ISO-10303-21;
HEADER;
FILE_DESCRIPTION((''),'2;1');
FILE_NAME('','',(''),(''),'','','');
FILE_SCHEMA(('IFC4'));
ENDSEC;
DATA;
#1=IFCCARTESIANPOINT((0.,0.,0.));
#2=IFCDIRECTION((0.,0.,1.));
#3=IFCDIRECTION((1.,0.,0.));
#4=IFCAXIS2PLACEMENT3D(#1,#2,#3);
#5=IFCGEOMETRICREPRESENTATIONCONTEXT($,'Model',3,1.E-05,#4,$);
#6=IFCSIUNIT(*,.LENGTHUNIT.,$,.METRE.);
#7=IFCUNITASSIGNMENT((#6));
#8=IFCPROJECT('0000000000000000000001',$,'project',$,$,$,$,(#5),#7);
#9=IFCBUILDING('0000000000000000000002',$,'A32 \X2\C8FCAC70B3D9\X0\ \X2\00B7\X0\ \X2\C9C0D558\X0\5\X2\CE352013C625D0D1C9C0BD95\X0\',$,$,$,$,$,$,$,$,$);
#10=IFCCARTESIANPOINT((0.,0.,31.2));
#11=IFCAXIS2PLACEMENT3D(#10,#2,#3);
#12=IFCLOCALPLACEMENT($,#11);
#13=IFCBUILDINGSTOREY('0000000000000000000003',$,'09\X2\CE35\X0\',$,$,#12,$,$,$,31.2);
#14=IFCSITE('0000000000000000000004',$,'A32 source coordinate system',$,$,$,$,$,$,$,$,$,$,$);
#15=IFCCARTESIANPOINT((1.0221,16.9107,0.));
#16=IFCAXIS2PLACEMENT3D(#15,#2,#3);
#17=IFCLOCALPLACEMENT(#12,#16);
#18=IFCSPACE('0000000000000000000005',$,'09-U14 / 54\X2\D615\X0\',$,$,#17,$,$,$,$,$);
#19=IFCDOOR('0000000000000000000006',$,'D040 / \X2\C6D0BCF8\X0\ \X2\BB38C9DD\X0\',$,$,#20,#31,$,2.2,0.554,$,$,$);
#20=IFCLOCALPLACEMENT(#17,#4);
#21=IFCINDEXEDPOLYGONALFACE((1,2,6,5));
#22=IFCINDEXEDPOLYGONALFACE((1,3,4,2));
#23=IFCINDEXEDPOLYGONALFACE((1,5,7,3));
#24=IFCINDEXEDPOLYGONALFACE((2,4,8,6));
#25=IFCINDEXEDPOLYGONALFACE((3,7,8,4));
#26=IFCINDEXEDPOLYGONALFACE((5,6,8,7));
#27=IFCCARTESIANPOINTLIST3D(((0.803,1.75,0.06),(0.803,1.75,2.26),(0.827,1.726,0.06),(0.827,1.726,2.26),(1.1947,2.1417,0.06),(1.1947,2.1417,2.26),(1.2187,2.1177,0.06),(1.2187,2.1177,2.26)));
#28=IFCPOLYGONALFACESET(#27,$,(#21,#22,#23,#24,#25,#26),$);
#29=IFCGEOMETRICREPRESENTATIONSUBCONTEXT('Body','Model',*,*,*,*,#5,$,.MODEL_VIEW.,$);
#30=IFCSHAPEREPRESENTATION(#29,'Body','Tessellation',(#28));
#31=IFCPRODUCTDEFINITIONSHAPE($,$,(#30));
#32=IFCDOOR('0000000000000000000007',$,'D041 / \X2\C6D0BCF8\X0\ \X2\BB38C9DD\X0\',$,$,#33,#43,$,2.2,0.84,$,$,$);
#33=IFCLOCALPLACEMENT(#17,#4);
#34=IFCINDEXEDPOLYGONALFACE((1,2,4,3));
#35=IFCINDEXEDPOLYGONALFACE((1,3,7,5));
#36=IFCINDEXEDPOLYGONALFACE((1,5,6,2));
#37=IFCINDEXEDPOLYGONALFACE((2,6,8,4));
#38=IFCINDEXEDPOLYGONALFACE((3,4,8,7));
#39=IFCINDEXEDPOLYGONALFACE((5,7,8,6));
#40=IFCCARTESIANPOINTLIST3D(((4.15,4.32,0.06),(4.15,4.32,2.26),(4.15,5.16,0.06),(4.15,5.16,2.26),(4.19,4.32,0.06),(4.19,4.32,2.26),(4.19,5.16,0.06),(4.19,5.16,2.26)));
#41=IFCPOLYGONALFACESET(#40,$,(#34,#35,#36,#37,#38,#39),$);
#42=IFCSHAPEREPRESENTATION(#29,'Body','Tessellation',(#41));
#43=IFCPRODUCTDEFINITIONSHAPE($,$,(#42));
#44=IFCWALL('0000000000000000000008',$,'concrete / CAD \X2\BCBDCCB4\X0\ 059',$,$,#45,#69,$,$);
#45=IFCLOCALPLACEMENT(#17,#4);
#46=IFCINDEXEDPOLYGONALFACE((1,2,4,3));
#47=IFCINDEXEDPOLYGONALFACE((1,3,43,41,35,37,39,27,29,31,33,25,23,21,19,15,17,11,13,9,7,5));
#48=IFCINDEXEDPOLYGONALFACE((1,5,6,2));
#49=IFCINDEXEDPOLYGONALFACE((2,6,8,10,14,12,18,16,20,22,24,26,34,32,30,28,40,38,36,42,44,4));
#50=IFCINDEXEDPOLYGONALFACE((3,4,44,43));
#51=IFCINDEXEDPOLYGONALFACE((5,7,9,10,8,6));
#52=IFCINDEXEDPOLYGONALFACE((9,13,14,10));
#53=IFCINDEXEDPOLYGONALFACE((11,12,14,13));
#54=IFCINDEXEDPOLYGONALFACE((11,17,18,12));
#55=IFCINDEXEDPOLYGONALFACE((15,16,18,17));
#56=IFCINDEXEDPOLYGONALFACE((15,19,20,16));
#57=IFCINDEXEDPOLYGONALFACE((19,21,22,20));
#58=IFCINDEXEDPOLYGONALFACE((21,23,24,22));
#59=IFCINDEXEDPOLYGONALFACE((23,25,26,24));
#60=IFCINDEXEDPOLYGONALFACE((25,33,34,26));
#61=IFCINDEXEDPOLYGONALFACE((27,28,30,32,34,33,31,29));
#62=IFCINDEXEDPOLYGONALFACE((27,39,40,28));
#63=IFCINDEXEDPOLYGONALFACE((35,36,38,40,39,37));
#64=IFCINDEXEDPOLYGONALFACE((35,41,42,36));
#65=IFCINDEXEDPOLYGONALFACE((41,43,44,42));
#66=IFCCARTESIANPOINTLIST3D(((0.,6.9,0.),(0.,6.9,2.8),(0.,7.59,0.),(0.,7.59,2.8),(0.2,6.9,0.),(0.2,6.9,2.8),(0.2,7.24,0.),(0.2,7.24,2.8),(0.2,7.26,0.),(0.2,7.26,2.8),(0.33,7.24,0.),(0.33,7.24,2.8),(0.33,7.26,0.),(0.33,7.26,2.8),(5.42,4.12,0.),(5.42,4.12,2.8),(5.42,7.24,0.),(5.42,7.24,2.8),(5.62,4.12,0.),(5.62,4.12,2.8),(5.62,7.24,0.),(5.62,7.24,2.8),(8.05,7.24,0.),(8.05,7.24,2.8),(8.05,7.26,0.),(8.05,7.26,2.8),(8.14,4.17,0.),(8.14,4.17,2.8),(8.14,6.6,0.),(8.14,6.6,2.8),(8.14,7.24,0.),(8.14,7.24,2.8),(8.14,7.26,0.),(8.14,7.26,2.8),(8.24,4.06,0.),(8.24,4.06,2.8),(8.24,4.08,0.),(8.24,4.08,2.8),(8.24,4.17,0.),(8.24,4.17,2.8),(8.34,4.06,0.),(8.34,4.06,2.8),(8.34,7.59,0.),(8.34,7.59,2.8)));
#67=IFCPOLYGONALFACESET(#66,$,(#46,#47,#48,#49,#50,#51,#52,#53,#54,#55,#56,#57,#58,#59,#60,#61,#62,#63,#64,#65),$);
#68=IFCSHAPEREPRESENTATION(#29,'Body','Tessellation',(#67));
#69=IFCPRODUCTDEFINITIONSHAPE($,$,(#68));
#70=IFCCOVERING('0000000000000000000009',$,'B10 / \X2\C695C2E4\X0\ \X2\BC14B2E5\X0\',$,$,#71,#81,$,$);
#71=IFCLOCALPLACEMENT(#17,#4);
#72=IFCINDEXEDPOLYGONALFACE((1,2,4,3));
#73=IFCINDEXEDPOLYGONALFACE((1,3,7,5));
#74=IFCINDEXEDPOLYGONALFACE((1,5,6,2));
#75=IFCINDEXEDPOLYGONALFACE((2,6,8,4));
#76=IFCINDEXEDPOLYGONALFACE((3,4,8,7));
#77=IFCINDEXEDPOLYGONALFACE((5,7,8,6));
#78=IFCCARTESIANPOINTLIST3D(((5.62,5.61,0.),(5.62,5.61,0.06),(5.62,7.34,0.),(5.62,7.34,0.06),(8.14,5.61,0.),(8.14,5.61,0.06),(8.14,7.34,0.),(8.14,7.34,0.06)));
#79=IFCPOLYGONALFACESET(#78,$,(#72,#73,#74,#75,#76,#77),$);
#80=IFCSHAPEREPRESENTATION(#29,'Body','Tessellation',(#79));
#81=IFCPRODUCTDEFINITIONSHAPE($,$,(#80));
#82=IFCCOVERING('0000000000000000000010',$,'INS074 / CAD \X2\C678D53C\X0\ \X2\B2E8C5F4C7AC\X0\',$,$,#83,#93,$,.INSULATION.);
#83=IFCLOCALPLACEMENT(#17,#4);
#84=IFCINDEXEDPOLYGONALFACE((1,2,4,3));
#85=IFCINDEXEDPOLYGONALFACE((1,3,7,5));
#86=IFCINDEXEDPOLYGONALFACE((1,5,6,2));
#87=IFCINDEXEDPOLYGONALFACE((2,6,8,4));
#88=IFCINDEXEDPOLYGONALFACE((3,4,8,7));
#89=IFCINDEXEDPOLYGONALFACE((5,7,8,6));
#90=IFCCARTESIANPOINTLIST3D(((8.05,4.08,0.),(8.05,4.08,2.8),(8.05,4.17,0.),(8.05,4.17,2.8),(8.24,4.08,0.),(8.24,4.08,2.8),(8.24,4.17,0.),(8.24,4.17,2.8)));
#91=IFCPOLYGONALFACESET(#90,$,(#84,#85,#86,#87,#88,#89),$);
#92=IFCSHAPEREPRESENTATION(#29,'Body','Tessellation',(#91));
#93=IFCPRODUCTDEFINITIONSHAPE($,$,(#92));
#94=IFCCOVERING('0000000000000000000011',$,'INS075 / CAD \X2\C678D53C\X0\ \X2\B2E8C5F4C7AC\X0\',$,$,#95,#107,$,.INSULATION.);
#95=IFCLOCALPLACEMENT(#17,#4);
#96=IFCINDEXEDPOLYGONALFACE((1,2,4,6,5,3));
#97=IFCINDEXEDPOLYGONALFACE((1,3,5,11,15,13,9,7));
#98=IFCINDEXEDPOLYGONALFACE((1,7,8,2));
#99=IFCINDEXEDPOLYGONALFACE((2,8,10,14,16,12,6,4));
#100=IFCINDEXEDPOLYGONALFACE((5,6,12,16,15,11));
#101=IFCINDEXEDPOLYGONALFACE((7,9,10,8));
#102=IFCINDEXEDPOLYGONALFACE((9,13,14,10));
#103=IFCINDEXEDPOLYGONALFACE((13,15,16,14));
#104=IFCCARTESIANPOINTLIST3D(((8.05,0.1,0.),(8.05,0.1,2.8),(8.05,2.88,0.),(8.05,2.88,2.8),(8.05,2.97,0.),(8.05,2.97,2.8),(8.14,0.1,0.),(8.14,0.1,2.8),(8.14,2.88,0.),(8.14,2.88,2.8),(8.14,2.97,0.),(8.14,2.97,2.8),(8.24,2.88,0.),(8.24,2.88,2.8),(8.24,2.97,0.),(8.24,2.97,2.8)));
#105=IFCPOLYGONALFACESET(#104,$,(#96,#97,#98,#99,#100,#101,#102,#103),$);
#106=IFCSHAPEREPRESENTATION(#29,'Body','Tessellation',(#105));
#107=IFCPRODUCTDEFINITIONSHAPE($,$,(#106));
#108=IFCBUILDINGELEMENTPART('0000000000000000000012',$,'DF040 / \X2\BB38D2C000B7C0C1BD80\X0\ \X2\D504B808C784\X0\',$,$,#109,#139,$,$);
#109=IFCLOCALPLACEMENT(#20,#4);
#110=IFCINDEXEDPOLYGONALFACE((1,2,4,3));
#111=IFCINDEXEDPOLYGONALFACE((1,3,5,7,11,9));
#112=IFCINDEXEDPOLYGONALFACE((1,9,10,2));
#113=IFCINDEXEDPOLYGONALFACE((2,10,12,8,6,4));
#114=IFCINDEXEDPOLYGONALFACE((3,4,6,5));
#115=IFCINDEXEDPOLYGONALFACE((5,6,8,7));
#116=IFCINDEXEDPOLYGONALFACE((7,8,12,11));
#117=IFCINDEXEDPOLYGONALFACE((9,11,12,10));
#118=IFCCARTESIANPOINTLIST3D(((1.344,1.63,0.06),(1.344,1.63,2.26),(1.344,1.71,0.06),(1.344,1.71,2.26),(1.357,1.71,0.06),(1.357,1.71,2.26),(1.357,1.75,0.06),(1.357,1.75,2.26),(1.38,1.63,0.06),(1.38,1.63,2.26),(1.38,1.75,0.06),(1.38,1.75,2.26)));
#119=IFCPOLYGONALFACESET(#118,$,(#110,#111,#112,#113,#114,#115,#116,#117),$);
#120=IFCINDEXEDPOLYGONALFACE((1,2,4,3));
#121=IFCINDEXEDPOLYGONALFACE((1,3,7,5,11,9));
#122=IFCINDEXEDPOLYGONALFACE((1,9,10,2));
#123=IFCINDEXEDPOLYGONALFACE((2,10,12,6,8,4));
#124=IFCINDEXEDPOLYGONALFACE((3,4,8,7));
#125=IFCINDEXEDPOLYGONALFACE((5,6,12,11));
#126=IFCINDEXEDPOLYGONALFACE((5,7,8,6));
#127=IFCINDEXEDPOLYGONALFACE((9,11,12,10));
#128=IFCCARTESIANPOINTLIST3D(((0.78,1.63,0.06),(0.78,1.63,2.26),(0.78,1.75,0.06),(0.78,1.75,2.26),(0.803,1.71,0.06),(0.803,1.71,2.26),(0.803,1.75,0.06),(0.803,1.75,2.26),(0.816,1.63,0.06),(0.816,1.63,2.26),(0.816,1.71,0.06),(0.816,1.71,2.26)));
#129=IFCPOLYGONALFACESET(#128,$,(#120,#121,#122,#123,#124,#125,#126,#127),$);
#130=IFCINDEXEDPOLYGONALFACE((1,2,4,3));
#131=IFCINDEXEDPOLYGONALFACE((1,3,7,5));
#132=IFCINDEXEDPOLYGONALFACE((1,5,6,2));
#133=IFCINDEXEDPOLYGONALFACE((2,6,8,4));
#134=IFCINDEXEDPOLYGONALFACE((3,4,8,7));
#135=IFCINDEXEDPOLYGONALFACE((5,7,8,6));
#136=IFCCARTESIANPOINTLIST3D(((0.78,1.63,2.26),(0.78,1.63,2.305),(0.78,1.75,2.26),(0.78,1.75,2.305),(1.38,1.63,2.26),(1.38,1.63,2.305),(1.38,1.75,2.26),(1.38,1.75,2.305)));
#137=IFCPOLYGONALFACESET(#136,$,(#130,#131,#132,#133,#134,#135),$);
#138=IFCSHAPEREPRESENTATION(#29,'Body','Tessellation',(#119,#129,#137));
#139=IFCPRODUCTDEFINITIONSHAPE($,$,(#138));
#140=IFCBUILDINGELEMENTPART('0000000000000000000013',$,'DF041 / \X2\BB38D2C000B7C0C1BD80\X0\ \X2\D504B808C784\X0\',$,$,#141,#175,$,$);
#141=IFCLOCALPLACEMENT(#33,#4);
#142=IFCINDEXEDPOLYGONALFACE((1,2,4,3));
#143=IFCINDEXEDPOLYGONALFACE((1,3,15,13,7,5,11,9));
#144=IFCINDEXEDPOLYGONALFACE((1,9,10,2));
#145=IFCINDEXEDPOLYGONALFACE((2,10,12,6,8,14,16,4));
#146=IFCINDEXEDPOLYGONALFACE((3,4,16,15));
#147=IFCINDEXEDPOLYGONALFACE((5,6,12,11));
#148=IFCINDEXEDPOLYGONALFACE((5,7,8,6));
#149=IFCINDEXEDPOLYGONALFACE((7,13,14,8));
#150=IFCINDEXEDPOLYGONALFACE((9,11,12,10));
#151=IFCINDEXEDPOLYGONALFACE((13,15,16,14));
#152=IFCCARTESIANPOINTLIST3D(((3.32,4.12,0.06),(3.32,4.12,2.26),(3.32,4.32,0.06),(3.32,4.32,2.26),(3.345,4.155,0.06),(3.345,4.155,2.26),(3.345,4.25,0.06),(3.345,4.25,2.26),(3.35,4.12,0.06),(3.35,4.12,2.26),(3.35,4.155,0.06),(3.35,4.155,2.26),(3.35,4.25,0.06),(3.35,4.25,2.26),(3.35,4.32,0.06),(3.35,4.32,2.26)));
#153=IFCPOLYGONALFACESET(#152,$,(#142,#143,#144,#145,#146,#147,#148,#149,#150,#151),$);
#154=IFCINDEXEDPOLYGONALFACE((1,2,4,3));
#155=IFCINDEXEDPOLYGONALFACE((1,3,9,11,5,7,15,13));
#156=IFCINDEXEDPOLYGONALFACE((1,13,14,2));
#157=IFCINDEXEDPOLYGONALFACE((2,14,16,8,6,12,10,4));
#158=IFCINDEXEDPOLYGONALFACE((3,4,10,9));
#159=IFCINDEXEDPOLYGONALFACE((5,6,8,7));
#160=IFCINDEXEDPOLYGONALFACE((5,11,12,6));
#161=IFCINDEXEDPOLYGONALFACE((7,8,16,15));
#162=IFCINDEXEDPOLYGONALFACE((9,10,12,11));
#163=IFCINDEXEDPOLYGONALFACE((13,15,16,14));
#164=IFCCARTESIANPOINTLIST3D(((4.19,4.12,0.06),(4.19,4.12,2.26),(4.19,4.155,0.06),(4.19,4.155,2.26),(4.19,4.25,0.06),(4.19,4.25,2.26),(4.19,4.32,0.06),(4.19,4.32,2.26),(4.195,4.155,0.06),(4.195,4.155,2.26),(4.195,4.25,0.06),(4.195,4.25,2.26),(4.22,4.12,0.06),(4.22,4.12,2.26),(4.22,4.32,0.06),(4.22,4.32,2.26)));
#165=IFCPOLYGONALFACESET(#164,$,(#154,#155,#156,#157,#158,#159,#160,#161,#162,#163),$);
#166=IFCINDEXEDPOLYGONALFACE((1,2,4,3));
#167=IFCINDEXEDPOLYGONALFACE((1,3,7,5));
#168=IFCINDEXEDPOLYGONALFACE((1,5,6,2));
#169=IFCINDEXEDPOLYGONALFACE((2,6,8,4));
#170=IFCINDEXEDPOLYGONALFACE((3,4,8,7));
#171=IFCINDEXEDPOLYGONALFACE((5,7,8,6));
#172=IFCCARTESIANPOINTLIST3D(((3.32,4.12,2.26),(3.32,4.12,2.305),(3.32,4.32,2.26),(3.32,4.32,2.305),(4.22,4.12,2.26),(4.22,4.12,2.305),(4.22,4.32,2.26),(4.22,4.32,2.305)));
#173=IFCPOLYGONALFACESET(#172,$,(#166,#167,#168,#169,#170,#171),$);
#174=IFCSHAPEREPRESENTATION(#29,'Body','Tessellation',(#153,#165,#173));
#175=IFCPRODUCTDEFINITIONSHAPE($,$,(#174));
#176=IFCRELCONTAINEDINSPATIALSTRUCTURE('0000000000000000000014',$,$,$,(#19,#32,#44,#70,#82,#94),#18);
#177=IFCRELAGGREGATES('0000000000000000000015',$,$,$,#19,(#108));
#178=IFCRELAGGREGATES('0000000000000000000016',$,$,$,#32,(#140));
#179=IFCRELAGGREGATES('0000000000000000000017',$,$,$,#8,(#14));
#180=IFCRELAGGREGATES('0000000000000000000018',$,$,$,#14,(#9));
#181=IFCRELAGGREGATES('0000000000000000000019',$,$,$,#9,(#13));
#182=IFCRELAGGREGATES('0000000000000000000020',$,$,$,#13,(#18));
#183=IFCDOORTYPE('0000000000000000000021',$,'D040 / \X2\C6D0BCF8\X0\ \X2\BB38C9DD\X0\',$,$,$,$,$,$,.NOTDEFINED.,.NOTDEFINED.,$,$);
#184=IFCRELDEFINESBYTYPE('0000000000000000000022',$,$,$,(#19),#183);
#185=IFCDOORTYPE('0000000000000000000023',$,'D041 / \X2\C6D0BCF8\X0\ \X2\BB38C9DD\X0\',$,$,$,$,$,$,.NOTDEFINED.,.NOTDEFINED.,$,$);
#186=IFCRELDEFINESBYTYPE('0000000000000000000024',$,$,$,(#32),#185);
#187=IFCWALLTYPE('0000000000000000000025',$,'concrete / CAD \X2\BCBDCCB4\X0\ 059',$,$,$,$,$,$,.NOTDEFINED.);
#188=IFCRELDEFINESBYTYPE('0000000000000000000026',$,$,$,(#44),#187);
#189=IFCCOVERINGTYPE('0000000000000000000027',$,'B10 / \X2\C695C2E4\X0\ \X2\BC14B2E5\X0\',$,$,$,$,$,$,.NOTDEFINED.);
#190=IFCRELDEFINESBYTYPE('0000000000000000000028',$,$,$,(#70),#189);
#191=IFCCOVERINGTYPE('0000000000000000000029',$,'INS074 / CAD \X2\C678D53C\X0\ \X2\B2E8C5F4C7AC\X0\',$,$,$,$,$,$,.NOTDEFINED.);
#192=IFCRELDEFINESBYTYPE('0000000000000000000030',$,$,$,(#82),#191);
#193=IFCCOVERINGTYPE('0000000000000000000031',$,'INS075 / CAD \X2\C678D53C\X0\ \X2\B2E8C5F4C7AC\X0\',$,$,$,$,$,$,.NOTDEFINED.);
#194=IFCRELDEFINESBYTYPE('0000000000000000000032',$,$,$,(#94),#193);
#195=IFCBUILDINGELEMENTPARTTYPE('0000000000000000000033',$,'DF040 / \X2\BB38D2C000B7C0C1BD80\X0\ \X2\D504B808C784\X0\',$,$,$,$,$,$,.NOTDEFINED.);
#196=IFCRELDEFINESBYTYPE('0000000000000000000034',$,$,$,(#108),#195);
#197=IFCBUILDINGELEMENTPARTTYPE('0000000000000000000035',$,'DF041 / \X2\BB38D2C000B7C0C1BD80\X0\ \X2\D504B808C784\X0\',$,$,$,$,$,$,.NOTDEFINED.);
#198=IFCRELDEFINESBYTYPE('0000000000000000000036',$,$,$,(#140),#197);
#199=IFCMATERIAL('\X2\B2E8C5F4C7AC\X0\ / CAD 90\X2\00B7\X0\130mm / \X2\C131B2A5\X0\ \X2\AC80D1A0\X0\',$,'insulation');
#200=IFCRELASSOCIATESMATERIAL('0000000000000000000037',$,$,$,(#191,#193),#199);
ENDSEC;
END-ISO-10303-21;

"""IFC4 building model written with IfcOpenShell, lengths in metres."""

from ifc_helpers import new_model, si_unit, frame, origin, origin_with_axes, place, context, subcontext, project, spatial, polyline, outline, extrude, source, transform, mapped, material, type_object, type_shapes, element, aggregate, save


model = new_model("IFC4")

# Units and contexts
model_context = context("Model", 3, precision=1e-05, world=origin_with_axes())
body_context = subcontext(model_context, "Body", "Model", "MODEL_VIEW")
ifc_project = project(units=[si_unit("LENGTHUNIT", "METRE")], contexts=[model_context])

# Site, building, storey, space
storey_placement = place(None, frame((0.0, 0.0, 31.2), z_axis=(0.0, 0.0, 1.0), x_axis=(1.0, 0.0, 0.0)))
space_1_placement = place(storey_placement, frame((1.0221, 16.9107, 0.0), z_axis=(0.0, 0.0, 1.0), x_axis=(1.0, 0.0, 0.0)))
site = spatial("IfcSite", under=ifc_project, Name="A32 source coordinate system")
building = spatial("IfcBuilding", under=site, Name="A32 주거동 · 지하5층–옥탑지붕")
storey = spatial("IfcBuildingStorey", under=building, at=storey_placement, Name="09층", Elevation=31.2)
space_1 = spatial("IfcSpace", under=storey, at=space_1_placement, Name="09-U14 / 54형")

# Doors
door_type_1 = type_object("IfcDoorType", Name="D040 / 원본 문짝", OperationType="NOTDEFINED", PredefinedType="NOTDEFINED")
shared_shape_1 = source(origin(), body_context, "Body", "SweptSolid", [
    extrude(outline(polyline([(0.803, 1.75), (1.1947, 2.1417), (1.2187, 2.1177), (0.827, 1.726), (0.803, 1.75)])), frame((0.0, 0.0, 0.06)), (0.0, 0.0, 1.0), 2.2),
])
type_shapes(door_type_1, [shared_shape_1])
door_1_placement = place(space_1_placement, origin_with_axes())
door_1 = element("IfcDoor", 1, at=door_1_placement, inside=space_1, type_object=door_type_1, Name="D040 / 원본 문짝", OverallHeight=2.2, OverallWidth=0.554, context=body_context, shape_type="MappedRepresentation", body=[
    mapped(shared_shape_1, transform((0.0, 0.0, 0.0), scale=1.0)),
])
door_type_2 = type_object("IfcDoorType", Name="D041 / 원본 문짝", OperationType="NOTDEFINED", PredefinedType="NOTDEFINED")
shared_shape_2 = source(origin(), body_context, "Body", "SweptSolid", [
    extrude(outline(polyline([(4.15, 5.16), (4.19, 5.16), (4.19, 4.32), (4.15, 4.32), (4.15, 5.16)])), frame((0.0, 0.0, 0.06)), (0.0, 0.0, 1.0), 2.2),
])
type_shapes(door_type_2, [shared_shape_2])
door_2_placement = place(space_1_placement, origin_with_axes())
door_2 = element("IfcDoor", 2, at=door_2_placement, inside=space_1, type_object=door_type_2, Name="D041 / 원본 문짝", OverallHeight=2.2, OverallWidth=0.84, context=body_context, shape_type="MappedRepresentation", body=[
    mapped(shared_shape_2, transform((0.0, 0.0, 0.0), scale=1.0)),
])

# Wall
wall_type_1 = type_object("IfcWallType", Name="concrete / CAD 벽체 059", PredefinedType="NOTDEFINED")
shared_shape_3 = source(origin(), body_context, "Body", "SweptSolid", [
    extrude(outline(polyline([(8.05, 7.26), (8.05, 7.24), (5.62, 7.24), (5.62, 4.12), (5.42, 4.12), (5.42, 7.24), (0.33, 7.24), (0.33, 7.26), (0.2, 7.26), (0.2, 7.24), (0.2, 6.9), (0.0, 6.9), (0.0, 7.59), (8.34, 7.59), (8.34, 4.06), (8.24, 4.06), (8.24, 4.08), (8.24, 4.17), (8.14, 4.17), (8.14, 6.6), (8.14, 7.24), (8.14, 7.26), (8.05, 7.26)])), origin(), (0.0, 0.0, 1.0), 2.8),
])
type_shapes(wall_type_1, [shared_shape_3])
wall_1_placement = place(space_1_placement, origin_with_axes())
element("IfcWall", 3, at=wall_1_placement, inside=space_1, type_object=wall_type_1, Name="concrete / CAD 벽체 059", context=body_context, shape_type="MappedRepresentation", body=[
    mapped(shared_shape_3, transform((0.0, 0.0, 0.0), scale=1.0)),
])

# Coverings
covering_type_1 = type_object("IfcCoveringType", Name="B10 / 욕실 바닥", PredefinedType="NOTDEFINED")
shared_shape_4 = source(origin(), body_context, "Body", "SweptSolid", [
    extrude(outline(polyline([(8.14, 5.61), (5.62, 5.61), (5.62, 7.34), (8.14, 7.34), (8.14, 5.61)])), origin(), (0.0, 0.0, 1.0), 0.06),
])
type_shapes(covering_type_1, [shared_shape_4])
covering_1_placement = place(space_1_placement, origin_with_axes())
element("IfcCovering", 4, at=covering_1_placement, inside=space_1, type_object=covering_type_1, Name="B10 / 욕실 바닥", context=body_context, shape_type="MappedRepresentation", body=[
    mapped(shared_shape_4, transform((0.0, 0.0, 0.0), scale=1.0)),
])
ifc_material = material(Name="단열재 / CAD 90·130mm / 성능 검토", Category="insulation")
covering_type_2 = type_object("IfcCoveringType", Name="INS074 / CAD 외피 단열재", PredefinedType="NOTDEFINED", material=ifc_material)
shared_shape_5 = source(origin(), body_context, "Body", "SweptSolid", [
    extrude(outline(polyline([(8.05, 4.08), (8.05, 4.17), (8.24, 4.17), (8.24, 4.08), (8.05, 4.08)])), origin(), (0.0, 0.0, 1.0), 2.8),
])
type_shapes(covering_type_2, [shared_shape_5])
covering_2_placement = place(space_1_placement, origin_with_axes())
element("IfcCovering", 5, at=covering_2_placement, inside=space_1, type_object=covering_type_2, Name="INS074 / CAD 외피 단열재", PredefinedType="INSULATION", context=body_context, shape_type="MappedRepresentation", body=[
    mapped(shared_shape_5, transform((0.0, 0.0, 0.0), scale=1.0)),
])
covering_type_3 = type_object("IfcCoveringType", Name="INS075 / CAD 외피 단열재", PredefinedType="NOTDEFINED", material=ifc_material)
shared_shape_6 = source(origin(), body_context, "Body", "SweptSolid", [
    extrude(outline(polyline([(8.24, 2.88), (8.14, 2.88), (8.14, 0.1), (8.05, 0.1), (8.05, 2.88), (8.05, 2.97), (8.14, 2.97), (8.24, 2.97), (8.24, 2.88)])), origin(), (0.0, 0.0, 1.0), 2.8),
])
type_shapes(covering_type_3, [shared_shape_6])
covering_3_placement = place(space_1_placement, origin_with_axes())
element("IfcCovering", 6, at=covering_3_placement, inside=space_1, type_object=covering_type_3, Name="INS075 / CAD 외피 단열재", PredefinedType="INSULATION", context=body_context, shape_type="MappedRepresentation", body=[
    mapped(shared_shape_6, transform((0.0, 0.0, 0.0), scale=1.0)),
])

# Building element parts
building_element_part_type_1 = type_object("IfcBuildingElementPartType", Name="DF040 / 문틀·상부 프레임", PredefinedType="NOTDEFINED")
shared_shape_7 = source(origin(), body_context, "Body", "SweptSolid", [
    extrude(outline(polyline([(1.344, 1.63), (1.344, 1.71), (1.357, 1.71), (1.357, 1.75), (1.38, 1.75), (1.38, 1.63), (1.344, 1.63)])), frame((0.0, 0.0, 0.06)), (0.0, 0.0, 1.0), 2.2),
    extrude(outline(polyline([(0.78, 1.75), (0.803, 1.75), (0.803, 1.71), (0.816, 1.71), (0.816, 1.63), (0.78, 1.63), (0.78, 1.75)])), frame((0.0, 0.0, 0.06)), (0.0, 0.0, 1.0), 2.2),
    extrude(outline(polyline([(0.78, 1.63), (0.78, 1.75), (1.38, 1.75), (1.38, 1.63), (0.78, 1.63)])), frame((0.0, 0.0, 2.26)), (0.0, 0.0, 1.0), 0.045),
])
type_shapes(building_element_part_type_1, [shared_shape_7])
building_element_part_1_placement = place(door_1_placement, origin_with_axes())
building_element_part_1 = element("IfcBuildingElementPart", 7, at=building_element_part_1_placement, type_object=building_element_part_type_1, Name="DF040 / 문틀·상부 프레임", context=body_context, shape_type="MappedRepresentation", body=[
    mapped(shared_shape_7, transform((0.0, 0.0, 0.0), scale=1.0)),
])
aggregate(door_1, [building_element_part_1])
building_element_part_type_2 = type_object("IfcBuildingElementPartType", Name="DF041 / 문틀·상부 프레임", PredefinedType="NOTDEFINED")
shared_shape_8 = source(origin(), body_context, "Body", "SweptSolid", [
    extrude(outline(polyline([(3.35, 4.32), (3.35, 4.25), (3.345, 4.25), (3.345, 4.155), (3.35, 4.155), (3.35, 4.12), (3.32, 4.12), (3.32, 4.32), (3.35, 4.32)])), frame((0.0, 0.0, 0.06)), (0.0, 0.0, 1.0), 2.2),
    extrude(outline(polyline([(4.22, 4.12), (4.19, 4.12), (4.19, 4.155), (4.195, 4.155), (4.195, 4.25), (4.19, 4.25), (4.19, 4.32), (4.22, 4.32), (4.22, 4.12)])), frame((0.0, 0.0, 0.06)), (0.0, 0.0, 1.0), 2.2),
    extrude(outline(polyline([(3.32, 4.12), (3.32, 4.32), (4.22, 4.32), (4.22, 4.12), (3.32, 4.12)])), frame((0.0, 0.0, 2.26)), (0.0, 0.0, 1.0), 0.045),
])
type_shapes(building_element_part_type_2, [shared_shape_8])
building_element_part_2_placement = place(door_2_placement, origin_with_axes())
building_element_part_2 = element("IfcBuildingElementPart", 8, at=building_element_part_2_placement, type_object=building_element_part_type_2, Name="DF041 / 문틀·상부 프레임", context=body_context, shape_type="MappedRepresentation", body=[
    mapped(shared_shape_8, transform((0.0, 0.0, 0.0), scale=1.0)),
])
aggregate(door_2, [building_element_part_2])

save(model, "model.ifc")
